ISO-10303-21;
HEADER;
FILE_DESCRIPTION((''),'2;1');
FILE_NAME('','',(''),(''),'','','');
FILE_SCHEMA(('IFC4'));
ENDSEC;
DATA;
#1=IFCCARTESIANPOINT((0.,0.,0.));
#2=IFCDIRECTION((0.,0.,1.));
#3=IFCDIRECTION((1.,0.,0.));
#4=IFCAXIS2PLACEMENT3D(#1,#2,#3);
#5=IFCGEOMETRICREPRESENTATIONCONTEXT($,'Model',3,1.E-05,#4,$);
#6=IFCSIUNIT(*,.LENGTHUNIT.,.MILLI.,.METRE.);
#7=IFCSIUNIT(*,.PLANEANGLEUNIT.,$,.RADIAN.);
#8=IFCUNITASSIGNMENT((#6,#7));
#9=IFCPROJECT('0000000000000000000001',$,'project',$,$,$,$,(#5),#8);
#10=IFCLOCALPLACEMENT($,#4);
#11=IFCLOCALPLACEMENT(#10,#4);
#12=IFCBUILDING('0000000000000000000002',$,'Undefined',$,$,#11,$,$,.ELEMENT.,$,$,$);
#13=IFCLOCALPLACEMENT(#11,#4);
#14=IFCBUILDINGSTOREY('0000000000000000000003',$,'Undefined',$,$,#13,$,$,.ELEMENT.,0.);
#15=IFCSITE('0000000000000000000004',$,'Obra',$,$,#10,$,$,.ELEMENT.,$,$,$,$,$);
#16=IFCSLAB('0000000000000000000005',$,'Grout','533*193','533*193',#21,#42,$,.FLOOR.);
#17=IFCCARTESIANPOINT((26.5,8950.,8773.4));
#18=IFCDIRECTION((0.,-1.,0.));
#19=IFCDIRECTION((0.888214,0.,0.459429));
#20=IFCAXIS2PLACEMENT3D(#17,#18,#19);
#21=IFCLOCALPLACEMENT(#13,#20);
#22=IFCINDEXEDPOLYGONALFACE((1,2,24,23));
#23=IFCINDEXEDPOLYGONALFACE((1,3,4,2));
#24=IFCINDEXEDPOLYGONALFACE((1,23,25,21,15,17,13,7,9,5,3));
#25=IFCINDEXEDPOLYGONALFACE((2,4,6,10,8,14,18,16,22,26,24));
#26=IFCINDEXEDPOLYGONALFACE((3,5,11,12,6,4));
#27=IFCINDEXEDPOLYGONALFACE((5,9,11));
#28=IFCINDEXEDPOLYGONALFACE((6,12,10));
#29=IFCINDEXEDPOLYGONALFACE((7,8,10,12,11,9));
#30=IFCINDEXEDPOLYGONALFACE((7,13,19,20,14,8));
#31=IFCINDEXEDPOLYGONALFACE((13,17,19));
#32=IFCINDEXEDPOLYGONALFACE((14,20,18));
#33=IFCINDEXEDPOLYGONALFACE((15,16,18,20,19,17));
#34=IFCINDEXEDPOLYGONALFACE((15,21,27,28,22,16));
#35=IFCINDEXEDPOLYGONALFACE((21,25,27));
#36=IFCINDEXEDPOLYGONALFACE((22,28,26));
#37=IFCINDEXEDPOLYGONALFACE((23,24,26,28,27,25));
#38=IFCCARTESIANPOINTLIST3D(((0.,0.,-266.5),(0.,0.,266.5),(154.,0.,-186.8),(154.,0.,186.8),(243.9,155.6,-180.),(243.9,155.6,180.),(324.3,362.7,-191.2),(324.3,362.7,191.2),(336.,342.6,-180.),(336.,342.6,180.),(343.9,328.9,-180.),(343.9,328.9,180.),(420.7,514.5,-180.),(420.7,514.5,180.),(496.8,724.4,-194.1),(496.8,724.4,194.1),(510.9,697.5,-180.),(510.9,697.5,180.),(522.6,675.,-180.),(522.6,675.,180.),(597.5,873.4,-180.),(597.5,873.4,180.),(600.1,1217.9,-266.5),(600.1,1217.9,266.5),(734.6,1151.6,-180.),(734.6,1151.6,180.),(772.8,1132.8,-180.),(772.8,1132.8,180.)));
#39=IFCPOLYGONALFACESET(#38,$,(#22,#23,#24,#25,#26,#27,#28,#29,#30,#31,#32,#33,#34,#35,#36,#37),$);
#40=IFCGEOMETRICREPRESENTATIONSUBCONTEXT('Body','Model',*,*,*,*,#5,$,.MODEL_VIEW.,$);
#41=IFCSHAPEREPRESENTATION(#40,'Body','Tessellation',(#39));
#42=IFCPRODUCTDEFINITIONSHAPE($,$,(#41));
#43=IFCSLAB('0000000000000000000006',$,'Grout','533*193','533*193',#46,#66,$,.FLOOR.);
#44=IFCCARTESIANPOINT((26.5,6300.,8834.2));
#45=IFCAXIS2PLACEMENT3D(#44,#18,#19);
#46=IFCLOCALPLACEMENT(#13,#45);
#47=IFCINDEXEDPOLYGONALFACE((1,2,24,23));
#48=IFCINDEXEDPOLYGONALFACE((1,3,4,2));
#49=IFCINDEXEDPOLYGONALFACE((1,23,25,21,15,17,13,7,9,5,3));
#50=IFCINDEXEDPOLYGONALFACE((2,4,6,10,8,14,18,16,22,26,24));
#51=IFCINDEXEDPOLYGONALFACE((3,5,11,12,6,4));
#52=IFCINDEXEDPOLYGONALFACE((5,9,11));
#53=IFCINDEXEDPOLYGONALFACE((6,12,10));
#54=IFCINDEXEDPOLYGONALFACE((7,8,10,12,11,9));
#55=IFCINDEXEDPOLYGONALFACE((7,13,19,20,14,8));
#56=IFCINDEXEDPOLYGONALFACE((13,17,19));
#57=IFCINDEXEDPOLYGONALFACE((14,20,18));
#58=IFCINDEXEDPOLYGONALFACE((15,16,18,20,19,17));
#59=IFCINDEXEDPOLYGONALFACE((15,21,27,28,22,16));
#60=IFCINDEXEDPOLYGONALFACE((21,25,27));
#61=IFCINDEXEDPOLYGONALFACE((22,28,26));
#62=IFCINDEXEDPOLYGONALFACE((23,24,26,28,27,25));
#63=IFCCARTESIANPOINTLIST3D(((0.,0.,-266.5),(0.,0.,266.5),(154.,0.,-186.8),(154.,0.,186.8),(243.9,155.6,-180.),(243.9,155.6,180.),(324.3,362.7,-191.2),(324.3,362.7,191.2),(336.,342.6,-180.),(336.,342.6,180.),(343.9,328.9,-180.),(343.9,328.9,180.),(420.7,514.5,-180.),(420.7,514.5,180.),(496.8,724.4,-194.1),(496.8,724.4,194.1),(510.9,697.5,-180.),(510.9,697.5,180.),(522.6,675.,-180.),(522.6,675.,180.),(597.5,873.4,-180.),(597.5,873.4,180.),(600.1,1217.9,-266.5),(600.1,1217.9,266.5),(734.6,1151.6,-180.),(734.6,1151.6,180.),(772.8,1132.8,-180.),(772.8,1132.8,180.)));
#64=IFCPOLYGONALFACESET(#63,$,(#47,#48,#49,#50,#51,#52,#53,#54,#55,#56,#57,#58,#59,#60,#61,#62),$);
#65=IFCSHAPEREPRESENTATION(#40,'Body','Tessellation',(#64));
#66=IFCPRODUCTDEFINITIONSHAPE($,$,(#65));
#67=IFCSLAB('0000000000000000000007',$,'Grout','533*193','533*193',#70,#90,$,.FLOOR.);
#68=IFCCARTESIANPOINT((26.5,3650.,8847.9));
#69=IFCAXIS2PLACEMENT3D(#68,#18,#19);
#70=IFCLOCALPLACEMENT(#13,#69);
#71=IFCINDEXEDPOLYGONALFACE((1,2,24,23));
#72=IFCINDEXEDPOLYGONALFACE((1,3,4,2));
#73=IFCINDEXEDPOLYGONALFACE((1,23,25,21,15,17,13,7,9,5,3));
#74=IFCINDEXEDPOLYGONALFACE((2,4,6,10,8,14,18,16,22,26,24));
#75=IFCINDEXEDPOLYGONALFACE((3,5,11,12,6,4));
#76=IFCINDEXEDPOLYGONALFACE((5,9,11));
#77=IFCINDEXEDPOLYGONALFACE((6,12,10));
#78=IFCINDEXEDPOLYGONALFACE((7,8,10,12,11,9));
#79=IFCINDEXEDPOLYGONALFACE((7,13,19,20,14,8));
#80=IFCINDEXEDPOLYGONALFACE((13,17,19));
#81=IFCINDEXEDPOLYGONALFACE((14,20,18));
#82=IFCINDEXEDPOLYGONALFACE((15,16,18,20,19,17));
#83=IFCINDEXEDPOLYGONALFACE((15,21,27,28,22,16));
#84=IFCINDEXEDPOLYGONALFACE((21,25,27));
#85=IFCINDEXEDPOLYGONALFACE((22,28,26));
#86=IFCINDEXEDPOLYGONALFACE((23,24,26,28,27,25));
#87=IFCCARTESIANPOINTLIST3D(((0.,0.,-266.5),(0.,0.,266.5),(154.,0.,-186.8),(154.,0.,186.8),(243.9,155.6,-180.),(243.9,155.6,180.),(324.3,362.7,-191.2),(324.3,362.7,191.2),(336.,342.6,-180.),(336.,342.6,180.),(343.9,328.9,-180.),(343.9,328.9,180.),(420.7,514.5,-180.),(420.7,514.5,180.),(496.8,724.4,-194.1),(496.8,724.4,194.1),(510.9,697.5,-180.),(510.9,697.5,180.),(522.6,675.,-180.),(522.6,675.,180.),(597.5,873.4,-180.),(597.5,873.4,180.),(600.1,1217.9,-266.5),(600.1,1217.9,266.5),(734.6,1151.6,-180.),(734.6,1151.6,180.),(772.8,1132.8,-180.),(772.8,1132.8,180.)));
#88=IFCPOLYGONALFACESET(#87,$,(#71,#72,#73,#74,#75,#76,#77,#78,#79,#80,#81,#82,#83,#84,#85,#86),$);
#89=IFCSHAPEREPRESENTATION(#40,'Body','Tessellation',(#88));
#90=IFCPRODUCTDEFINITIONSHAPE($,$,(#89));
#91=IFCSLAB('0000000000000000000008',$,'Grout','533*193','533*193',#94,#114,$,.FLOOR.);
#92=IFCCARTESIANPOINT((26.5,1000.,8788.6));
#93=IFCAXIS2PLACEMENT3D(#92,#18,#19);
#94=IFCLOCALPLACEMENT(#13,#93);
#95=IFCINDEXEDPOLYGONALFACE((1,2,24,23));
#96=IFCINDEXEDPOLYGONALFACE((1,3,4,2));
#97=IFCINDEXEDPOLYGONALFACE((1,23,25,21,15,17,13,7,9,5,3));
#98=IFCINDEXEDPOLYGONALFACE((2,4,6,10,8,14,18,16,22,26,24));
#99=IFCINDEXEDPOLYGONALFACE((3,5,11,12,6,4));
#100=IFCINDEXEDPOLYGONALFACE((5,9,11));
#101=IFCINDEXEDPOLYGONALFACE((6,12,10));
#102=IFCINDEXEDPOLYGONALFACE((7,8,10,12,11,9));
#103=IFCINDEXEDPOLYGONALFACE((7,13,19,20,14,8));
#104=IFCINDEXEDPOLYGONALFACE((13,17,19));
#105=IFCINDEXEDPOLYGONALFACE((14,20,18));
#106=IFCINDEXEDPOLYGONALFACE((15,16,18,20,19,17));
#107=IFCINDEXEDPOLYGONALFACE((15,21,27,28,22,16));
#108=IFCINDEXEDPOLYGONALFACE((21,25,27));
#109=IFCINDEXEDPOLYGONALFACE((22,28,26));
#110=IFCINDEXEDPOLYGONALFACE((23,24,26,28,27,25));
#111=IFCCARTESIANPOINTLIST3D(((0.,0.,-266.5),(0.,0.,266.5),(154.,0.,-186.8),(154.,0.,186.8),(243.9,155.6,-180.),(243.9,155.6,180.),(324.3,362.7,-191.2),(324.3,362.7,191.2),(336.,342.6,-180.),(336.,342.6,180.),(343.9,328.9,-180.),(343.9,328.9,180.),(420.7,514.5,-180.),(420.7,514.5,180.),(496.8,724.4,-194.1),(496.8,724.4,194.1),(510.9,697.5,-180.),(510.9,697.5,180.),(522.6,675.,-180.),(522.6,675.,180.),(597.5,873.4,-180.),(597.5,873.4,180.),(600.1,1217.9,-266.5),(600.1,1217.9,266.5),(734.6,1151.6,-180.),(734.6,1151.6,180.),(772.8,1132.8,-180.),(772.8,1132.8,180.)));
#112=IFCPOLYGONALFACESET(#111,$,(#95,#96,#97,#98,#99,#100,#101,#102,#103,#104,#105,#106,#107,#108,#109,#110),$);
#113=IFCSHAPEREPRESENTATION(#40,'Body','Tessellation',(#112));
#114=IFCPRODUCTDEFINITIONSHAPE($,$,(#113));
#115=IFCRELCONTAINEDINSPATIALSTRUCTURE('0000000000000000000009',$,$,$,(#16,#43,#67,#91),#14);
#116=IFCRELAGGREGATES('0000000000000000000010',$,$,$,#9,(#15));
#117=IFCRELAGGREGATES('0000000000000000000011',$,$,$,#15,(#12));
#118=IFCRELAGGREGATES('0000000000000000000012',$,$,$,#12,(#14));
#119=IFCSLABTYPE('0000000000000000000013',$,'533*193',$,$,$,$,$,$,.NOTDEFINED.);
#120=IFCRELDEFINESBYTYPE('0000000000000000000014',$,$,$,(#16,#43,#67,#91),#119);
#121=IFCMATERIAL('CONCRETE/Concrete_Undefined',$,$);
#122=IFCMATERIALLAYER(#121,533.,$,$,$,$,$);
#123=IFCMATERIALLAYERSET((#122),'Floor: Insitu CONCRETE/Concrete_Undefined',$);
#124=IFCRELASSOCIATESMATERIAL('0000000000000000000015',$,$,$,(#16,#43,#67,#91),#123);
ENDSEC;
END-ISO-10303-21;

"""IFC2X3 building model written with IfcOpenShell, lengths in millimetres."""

from ifc_helpers import new_model, si_unit, frame, origin_with_axes, place, context, subcontext, project, spatial, polyline, outline, extrude, boolean, material, layer, layer_set, layer_usage, type_object, element, save


model = new_model("IFC2X3")

# Units and contexts
model_context = context("Model", 3, precision=1e-05, world=origin_with_axes())
body_context = subcontext(model_context, "Body", "Model", "MODEL_VIEW")
ifc_project = project(units=[si_unit("LENGTHUNIT", "METRE", prefix="MILLI"), si_unit("PLANEANGLEUNIT", "RADIAN")], contexts=[model_context])

# Site, building, storey
site_placement = place(None, origin_with_axes())
site = spatial("IfcSite", under=ifc_project, at=site_placement, Name="Obra", CompositionType="ELEMENT")
building_placement = place(site_placement, origin_with_axes())
building = spatial("IfcBuilding", under=site, at=building_placement, Name="Undefined", CompositionType="ELEMENT")
storey_placement = place(building_placement, origin_with_axes())
storey = spatial("IfcBuildingStorey", under=building, at=storey_placement, Name="Undefined", CompositionType="ELEMENT", Elevation=0.0)

# Slabs
ifc_material_1 = material(Name="CONCRETE/Concrete_Undefined")
ifc_layer_1 = layer(ifc_material_1, 533.0)
ifc_layer_set_1 = layer_set([ifc_layer_1], Name="Floor: Insitu CONCRETE/Concrete_Undefined")
ifc_layer_usage_1 = layer_usage(ifc_layer_set_1, "AXIS3", "POSITIVE", -266.5)
slab_type_1 = type_object("IfcSlabType", Name="533*193", PredefinedType="NOTDEFINED")
slab_1_placement = place(storey_placement, frame((26.5, 8950.0, 8773.4), z_axis=(0.0, -1.0, 0.0), x_axis=(0.888214, 0.0, 0.459429)))
element("IfcSlab", 1, at=slab_1_placement, inside=storey, type_object=slab_type_1, material=ifc_layer_usage_1, Name="Grout", Description="533*193", ObjectType="533*193", PredefinedType="FLOOR", context=body_context, shape_type="CSG", body=[
    boolean("DIFFERENCE", boolean("DIFFERENCE", extrude(outline(polyline([(0.0, 0.0), (154.0, 0.0), (343.9, 328.9), (324.3, 362.7), (522.6, 675.0), (496.8, 724.4), (772.8, 1132.8), (600.1, 1217.9), (0.0, 0.0)])), frame((0.0, 0.0, -266.5), z_axis=(0.0, 0.0, 1.0), x_axis=(1.0, 0.0, 0.0)), (0.0, 0.0, 1.0), 533.0), extrude(outline(polyline([(0.0, 0.0), (173.2, 0.0), (210.0, 21.3), (166.8, 96.2), (0.0, 0.0)])), frame((611.1, 1240.3, 266.5), z_axis=(-0.44198, -0.897025, 0.0), x_axis=(0.777076, -0.382879, -0.499556)), (0.0, 0.0, 1.0), 1400.0)), extrude(outline(polyline([(0.0, 0.0), (173.2, 0.0), (210.0, 21.3), (166.8, 96.2), (0.0, 0.0)])), frame((-7.7, -15.5, -266.5), z_axis=(0.44198, 0.897025, 0.0), x_axis=(0.777076, -0.382879, 0.499556)), (0.0, 0.0, 1.0), 1400.0)),
])
ifc_layer_usage_2 = layer_usage(ifc_layer_set_1, "AXIS3", "POSITIVE", -266.5)
slab_2_placement = place(storey_placement, frame((26.5, 6300.0, 8834.2), z_axis=(0.0, -1.0, 0.0), x_axis=(0.888214, 0.0, 0.459429)))
element("IfcSlab", 2, at=slab_2_placement, inside=storey, type_object=slab_type_1, material=ifc_layer_usage_2, Name="Grout", Description="533*193", ObjectType="533*193", PredefinedType="FLOOR", context=body_context, shape_type="CSG", body=[
    boolean("DIFFERENCE", boolean("DIFFERENCE", extrude(outline(polyline([(0.0, 0.0), (154.0, 0.0), (343.9, 328.9), (324.3, 362.7), (522.6, 675.0), (496.8, 724.4), (772.8, 1132.8), (600.1, 1217.9), (0.0, 0.0)])), frame((0.0, 0.0, -266.5), z_axis=(0.0, 0.0, 1.0), x_axis=(1.0, 0.0, 0.0)), (0.0, 0.0, 1.0), 533.0), extrude(outline(polyline([(0.0, 0.0), (173.2, 0.0), (210.0, 21.3), (166.8, 96.2), (0.0, 0.0)])), frame((611.1, 1240.3, 266.5), z_axis=(-0.44198, -0.897025, 0.0), x_axis=(0.777076, -0.382879, -0.499556)), (0.0, 0.0, 1.0), 1400.0)), extrude(outline(polyline([(0.0, 0.0), (173.2, 0.0), (210.0, 21.3), (166.8, 96.2), (0.0, 0.0)])), frame((-7.7, -15.5, -266.5), z_axis=(0.44198, 0.897025, 0.0), x_axis=(0.777076, -0.382879, 0.499556)), (0.0, 0.0, 1.0), 1400.0)),
])
ifc_layer_usage_3 = layer_usage(ifc_layer_set_1, "AXIS3", "POSITIVE", -266.5)
slab_3_placement = place(storey_placement, frame((26.5, 3650.0, 8847.9), z_axis=(0.0, -1.0, 0.0), x_axis=(0.888214, 0.0, 0.459429)))
element("IfcSlab", 3, at=slab_3_placement, inside=storey, type_object=slab_type_1, material=ifc_layer_usage_3, Name="Grout", Description="533*193", ObjectType="533*193", PredefinedType="FLOOR", context=body_context, shape_type="CSG", body=[
    boolean("DIFFERENCE", boolean("DIFFERENCE", extrude(outline(polyline([(0.0, 0.0), (154.0, 0.0), (343.9, 328.9), (324.3, 362.7), (522.6, 675.0), (496.8, 724.4), (772.8, 1132.8), (600.1, 1217.9), (0.0, 0.0)])), frame((0.0, 0.0, -266.5), z_axis=(0.0, 0.0, 1.0), x_axis=(1.0, 0.0, 0.0)), (0.0, 0.0, 1.0), 533.0), extrude(outline(polyline([(0.0, 0.0), (173.2, 0.0), (210.0, 21.3), (166.8, 96.2), (0.0, 0.0)])), frame((611.1, 1240.3, 266.5), z_axis=(-0.44198, -0.897025, 0.0), x_axis=(0.777076, -0.382879, -0.499556)), (0.0, 0.0, 1.0), 1400.0)), extrude(outline(polyline([(0.0, 0.0), (173.2, 0.0), (210.0, 21.3), (166.8, 96.2), (0.0, 0.0)])), frame((-7.7, -15.5, -266.5), z_axis=(0.44198, 0.897025, 0.0), x_axis=(0.777076, -0.382879, 0.499556)), (0.0, 0.0, 1.0), 1400.0)),
])
ifc_layer_usage_4 = layer_usage(ifc_layer_set_1, "AXIS3", "POSITIVE", -266.5)
slab_4_placement = place(storey_placement, frame((26.5, 1000.0, 8788.6), z_axis=(0.0, -1.0, 0.0), x_axis=(0.888214, 0.0, 0.459429)))
element("IfcSlab", 4, at=slab_4_placement, inside=storey, type_object=slab_type_1, material=ifc_layer_usage_4, Name="Grout", Description="533*193", ObjectType="533*193", PredefinedType="FLOOR", context=body_context, shape_type="CSG", body=[
    boolean("DIFFERENCE", boolean("DIFFERENCE", extrude(outline(polyline([(0.0, 0.0), (154.0, 0.0), (343.9, 328.9), (324.3, 362.7), (522.6, 675.0), (496.8, 724.4), (772.8, 1132.8), (600.1, 1217.9), (0.0, 0.0)])), frame((0.0, 0.0, -266.5), z_axis=(0.0, 0.0, 1.0), x_axis=(1.0, 0.0, 0.0)), (0.0, 0.0, 1.0), 533.0), extrude(outline(polyline([(0.0, 0.0), (173.2, 0.0), (210.0, 21.3), (166.8, 96.2), (0.0, 0.0)])), frame((611.1, 1240.3, 266.5), z_axis=(-0.44198, -0.897025, 0.0), x_axis=(0.777076, -0.382879, -0.499556)), (0.0, 0.0, 1.0), 1400.0)), extrude(outline(polyline([(0.0, 0.0), (173.2, 0.0), (210.0, 21.3), (166.8, 96.2), (0.0, 0.0)])), frame((-7.7, -15.5, -266.5), z_axis=(0.44198, 0.897025, 0.0), x_axis=(0.777076, -0.382879, 0.499556)), (0.0, 0.0, 1.0), 1400.0)),
])

save(model, "model.ifc")
